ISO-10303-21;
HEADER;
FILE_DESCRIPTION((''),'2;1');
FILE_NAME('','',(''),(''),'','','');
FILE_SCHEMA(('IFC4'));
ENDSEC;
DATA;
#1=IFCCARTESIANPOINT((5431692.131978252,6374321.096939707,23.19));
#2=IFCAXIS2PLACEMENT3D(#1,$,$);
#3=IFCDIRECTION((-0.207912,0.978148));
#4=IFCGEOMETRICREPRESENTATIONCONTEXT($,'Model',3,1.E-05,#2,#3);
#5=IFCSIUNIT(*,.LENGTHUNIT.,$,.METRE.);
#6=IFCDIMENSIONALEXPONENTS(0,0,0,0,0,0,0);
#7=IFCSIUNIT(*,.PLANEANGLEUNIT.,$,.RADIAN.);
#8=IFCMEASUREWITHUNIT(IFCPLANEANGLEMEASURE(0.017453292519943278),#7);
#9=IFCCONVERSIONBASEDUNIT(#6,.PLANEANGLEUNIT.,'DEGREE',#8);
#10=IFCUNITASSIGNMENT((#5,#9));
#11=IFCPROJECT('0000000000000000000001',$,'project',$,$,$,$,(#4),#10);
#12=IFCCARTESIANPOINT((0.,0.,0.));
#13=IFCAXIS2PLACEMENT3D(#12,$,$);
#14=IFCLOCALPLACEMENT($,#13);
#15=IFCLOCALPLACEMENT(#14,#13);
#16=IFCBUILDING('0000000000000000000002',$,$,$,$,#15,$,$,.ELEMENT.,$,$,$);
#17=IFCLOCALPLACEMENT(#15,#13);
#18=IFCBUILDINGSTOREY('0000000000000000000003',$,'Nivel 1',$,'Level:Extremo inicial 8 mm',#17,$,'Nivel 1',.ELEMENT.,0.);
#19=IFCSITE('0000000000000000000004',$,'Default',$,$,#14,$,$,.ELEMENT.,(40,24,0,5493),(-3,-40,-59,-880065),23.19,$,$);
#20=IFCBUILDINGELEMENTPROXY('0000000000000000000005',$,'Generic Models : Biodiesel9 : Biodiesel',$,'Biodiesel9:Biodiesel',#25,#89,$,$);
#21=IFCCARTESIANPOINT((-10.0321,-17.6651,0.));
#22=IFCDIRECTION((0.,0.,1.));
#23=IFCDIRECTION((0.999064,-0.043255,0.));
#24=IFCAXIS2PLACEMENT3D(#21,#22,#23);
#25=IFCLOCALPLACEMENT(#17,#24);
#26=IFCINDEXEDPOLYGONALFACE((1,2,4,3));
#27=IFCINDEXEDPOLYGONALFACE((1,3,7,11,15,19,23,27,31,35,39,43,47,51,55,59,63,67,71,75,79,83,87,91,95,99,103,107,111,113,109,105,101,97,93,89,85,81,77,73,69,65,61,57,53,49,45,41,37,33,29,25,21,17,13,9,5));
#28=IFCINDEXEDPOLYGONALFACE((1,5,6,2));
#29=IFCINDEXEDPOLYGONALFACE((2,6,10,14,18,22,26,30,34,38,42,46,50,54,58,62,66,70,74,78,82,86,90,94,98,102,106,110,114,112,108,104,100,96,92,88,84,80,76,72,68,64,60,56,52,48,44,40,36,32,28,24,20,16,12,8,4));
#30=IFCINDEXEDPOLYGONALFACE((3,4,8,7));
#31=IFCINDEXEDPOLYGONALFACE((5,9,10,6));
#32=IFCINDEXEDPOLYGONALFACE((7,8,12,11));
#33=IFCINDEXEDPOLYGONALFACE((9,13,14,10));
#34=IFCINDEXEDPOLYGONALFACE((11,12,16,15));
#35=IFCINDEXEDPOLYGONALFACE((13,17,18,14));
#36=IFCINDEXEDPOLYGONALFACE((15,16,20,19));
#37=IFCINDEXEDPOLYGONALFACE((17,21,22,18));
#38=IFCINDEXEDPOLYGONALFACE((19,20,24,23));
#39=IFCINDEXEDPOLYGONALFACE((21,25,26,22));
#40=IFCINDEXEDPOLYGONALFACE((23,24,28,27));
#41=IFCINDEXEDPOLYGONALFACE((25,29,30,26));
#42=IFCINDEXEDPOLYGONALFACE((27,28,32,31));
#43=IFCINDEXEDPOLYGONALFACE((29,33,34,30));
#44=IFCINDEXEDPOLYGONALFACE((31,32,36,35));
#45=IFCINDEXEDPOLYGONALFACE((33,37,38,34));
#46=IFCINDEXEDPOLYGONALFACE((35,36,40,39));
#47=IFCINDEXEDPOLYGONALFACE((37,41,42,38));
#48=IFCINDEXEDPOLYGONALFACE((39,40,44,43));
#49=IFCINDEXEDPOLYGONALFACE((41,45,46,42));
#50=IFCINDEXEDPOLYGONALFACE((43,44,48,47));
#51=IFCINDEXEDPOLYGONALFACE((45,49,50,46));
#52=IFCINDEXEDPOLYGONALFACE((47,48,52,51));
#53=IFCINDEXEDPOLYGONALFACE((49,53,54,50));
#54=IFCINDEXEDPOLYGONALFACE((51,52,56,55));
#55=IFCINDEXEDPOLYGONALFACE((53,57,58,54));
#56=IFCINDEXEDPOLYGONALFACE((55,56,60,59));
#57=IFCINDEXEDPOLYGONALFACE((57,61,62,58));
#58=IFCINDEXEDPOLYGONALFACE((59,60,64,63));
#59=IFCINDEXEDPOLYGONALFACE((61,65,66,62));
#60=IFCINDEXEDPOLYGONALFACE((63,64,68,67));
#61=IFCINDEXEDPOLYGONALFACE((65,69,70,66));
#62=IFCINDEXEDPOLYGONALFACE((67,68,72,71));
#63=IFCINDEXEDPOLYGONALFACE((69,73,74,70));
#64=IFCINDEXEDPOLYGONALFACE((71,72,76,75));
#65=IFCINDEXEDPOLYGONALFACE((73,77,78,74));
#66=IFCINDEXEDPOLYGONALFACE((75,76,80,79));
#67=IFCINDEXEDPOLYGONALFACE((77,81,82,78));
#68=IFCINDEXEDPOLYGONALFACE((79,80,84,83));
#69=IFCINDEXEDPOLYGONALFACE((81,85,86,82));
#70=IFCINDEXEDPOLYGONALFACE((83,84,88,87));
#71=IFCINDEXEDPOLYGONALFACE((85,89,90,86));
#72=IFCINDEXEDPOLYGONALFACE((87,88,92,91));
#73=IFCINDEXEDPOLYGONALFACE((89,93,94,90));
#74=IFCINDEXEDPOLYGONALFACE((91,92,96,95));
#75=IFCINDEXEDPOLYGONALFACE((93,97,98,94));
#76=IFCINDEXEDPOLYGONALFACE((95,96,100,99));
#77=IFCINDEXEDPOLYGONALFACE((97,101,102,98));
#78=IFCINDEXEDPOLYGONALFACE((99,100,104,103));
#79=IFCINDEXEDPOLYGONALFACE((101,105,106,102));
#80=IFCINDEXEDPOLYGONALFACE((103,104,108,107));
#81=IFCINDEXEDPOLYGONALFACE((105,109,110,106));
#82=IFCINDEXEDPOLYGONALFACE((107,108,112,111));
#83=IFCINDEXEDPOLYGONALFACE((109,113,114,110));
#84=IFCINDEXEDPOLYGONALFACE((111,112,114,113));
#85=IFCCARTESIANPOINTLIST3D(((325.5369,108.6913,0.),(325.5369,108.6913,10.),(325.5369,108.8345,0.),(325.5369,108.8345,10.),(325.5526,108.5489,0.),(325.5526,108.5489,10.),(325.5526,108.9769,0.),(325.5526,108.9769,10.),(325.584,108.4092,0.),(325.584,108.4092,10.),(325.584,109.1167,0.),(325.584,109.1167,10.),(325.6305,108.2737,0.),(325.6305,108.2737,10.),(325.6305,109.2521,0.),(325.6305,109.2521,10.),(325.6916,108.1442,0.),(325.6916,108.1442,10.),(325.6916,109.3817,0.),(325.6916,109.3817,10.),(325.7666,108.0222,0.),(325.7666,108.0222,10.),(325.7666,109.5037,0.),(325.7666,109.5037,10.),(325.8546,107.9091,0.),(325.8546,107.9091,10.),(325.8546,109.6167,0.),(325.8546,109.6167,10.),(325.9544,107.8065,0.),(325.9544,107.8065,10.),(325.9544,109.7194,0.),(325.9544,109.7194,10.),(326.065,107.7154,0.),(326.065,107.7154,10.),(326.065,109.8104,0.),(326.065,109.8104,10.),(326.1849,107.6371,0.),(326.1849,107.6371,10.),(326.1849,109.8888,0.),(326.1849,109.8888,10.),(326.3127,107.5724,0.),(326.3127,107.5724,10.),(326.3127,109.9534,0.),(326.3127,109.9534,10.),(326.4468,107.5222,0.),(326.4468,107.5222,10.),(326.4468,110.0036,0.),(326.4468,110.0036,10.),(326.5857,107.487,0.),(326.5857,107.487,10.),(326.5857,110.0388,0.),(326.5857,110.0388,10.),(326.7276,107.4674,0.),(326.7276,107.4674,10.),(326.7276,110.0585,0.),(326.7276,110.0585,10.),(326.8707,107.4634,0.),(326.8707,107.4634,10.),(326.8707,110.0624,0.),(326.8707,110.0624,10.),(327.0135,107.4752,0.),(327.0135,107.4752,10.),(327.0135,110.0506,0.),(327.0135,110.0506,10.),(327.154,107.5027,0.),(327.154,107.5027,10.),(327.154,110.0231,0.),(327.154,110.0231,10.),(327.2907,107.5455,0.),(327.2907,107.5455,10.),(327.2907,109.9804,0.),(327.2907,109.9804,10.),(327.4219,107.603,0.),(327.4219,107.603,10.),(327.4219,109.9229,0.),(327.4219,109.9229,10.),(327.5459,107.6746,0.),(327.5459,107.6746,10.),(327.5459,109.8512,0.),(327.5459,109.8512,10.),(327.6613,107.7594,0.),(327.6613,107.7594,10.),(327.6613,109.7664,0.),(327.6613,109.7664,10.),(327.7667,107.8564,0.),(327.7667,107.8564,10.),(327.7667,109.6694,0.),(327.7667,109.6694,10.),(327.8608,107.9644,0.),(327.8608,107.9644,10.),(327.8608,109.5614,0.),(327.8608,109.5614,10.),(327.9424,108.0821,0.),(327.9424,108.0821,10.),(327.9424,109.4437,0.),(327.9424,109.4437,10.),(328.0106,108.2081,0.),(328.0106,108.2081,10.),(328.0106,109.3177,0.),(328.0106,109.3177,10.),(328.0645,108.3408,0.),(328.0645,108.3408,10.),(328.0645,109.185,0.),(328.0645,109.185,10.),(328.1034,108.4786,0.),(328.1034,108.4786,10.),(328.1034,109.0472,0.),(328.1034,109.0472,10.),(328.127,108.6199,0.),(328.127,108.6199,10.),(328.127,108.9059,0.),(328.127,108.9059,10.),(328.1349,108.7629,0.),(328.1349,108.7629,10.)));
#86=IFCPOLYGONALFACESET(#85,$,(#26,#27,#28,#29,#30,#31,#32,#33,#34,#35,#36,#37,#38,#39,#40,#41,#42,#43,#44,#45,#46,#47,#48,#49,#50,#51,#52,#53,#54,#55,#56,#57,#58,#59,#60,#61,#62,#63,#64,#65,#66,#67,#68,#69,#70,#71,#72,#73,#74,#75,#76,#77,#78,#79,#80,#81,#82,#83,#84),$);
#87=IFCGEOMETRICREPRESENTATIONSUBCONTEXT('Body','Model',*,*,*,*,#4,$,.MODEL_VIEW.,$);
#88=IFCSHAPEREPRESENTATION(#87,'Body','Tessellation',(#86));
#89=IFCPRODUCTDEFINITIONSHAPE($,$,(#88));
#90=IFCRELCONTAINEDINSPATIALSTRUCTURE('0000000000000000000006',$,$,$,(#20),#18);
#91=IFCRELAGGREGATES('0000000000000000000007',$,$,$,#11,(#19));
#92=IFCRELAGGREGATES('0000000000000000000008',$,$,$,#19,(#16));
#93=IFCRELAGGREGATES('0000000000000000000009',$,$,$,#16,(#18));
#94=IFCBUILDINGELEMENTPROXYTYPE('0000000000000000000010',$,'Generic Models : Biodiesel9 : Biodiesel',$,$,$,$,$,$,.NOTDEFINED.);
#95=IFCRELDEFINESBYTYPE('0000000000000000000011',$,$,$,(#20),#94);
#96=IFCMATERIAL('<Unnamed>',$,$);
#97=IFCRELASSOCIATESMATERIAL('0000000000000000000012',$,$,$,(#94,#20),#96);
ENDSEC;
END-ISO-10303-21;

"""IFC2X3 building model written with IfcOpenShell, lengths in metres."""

from ifc_helpers import new_model, entity, si_unit, converted_unit, direction, frame, origin, origin_2d_with_axis, place, context, subcontext, project, spatial, circle, extrude, source, transform, mapped, material, type_object, type_shapes, element, save


model = new_model("IFC2X3")

# Units and contexts
model_context = context("Model", 3, precision=1e-05, world=frame((5431692.131978252, 6374321.096939707, 23.19)), true_north=direction((-0.207912, 0.978148)))
body_context = subcontext(model_context, "Body", "Model", "MODEL_VIEW")
ifc_project = project(units=[si_unit("LENGTHUNIT", "METRE"), converted_unit("PLANEANGLEUNIT", "DEGREE", entity("IfcPlaneAngleMeasure", 0.017453292519943278), si_unit("PLANEANGLEUNIT", "RADIAN"), dimensions=[0, 0, 0, 0, 0, 0, 0])], contexts=[model_context])

# Site, building, storey
site_placement = place(None, origin())
site = spatial("IfcSite", under=ifc_project, at=site_placement, Name="Default", CompositionType="ELEMENT", RefLatitude=(40, 24, 0, 5493), RefLongitude=(-3, -40, -59, -880065), RefElevation=23.19)
building_placement = place(site_placement, origin())
building = spatial("IfcBuilding", under=site, at=building_placement, CompositionType="ELEMENT")
storey_placement = place(building_placement, origin())
storey = spatial("IfcBuildingStorey", under=building, at=storey_placement, Name="Nivel 1", ObjectType="Level:Extremo inicial 8 mm", LongName="Nivel 1", CompositionType="ELEMENT", Elevation=0.0)

# Building element proxy
ifc_material_1 = material(Name="<Unnamed>")
building_element_proxy_type_1 = type_object("IfcBuildingElementProxyType", Name="Generic Models : Biodiesel9 : Biodiesel", PredefinedType="NOTDEFINED", material=ifc_material_1)
shared_shape_1 = source(origin(), body_context, "Body", "SweptSolid", [
    extrude(circle(Radius=1.3, at=origin_2d_with_axis()), frame((326.8349, 108.7629, 0.0)), (0.0, 0.0, 1.0), 10.0),
])
type_shapes(building_element_proxy_type_1, [shared_shape_1])
proxy_1_placement = place(storey_placement, frame((-10.0321, -17.6651, 0.0), z_axis=(0.0, 0.0, 1.0), x_axis=(0.999064, -0.043255, 0.0)))
element("IfcBuildingElementProxy", 1, at=proxy_1_placement, inside=storey, type_object=building_element_proxy_type_1, material=ifc_material_1, Name="Generic Models : Biodiesel9 : Biodiesel", ObjectType="Biodiesel9:Biodiesel", context=body_context, shape_type="MappedRepresentation", body=[
    mapped(shared_shape_1, transform((0.0, 0.0, 0.0), scale=1.0)),
])

save(model, "model.ifc")
